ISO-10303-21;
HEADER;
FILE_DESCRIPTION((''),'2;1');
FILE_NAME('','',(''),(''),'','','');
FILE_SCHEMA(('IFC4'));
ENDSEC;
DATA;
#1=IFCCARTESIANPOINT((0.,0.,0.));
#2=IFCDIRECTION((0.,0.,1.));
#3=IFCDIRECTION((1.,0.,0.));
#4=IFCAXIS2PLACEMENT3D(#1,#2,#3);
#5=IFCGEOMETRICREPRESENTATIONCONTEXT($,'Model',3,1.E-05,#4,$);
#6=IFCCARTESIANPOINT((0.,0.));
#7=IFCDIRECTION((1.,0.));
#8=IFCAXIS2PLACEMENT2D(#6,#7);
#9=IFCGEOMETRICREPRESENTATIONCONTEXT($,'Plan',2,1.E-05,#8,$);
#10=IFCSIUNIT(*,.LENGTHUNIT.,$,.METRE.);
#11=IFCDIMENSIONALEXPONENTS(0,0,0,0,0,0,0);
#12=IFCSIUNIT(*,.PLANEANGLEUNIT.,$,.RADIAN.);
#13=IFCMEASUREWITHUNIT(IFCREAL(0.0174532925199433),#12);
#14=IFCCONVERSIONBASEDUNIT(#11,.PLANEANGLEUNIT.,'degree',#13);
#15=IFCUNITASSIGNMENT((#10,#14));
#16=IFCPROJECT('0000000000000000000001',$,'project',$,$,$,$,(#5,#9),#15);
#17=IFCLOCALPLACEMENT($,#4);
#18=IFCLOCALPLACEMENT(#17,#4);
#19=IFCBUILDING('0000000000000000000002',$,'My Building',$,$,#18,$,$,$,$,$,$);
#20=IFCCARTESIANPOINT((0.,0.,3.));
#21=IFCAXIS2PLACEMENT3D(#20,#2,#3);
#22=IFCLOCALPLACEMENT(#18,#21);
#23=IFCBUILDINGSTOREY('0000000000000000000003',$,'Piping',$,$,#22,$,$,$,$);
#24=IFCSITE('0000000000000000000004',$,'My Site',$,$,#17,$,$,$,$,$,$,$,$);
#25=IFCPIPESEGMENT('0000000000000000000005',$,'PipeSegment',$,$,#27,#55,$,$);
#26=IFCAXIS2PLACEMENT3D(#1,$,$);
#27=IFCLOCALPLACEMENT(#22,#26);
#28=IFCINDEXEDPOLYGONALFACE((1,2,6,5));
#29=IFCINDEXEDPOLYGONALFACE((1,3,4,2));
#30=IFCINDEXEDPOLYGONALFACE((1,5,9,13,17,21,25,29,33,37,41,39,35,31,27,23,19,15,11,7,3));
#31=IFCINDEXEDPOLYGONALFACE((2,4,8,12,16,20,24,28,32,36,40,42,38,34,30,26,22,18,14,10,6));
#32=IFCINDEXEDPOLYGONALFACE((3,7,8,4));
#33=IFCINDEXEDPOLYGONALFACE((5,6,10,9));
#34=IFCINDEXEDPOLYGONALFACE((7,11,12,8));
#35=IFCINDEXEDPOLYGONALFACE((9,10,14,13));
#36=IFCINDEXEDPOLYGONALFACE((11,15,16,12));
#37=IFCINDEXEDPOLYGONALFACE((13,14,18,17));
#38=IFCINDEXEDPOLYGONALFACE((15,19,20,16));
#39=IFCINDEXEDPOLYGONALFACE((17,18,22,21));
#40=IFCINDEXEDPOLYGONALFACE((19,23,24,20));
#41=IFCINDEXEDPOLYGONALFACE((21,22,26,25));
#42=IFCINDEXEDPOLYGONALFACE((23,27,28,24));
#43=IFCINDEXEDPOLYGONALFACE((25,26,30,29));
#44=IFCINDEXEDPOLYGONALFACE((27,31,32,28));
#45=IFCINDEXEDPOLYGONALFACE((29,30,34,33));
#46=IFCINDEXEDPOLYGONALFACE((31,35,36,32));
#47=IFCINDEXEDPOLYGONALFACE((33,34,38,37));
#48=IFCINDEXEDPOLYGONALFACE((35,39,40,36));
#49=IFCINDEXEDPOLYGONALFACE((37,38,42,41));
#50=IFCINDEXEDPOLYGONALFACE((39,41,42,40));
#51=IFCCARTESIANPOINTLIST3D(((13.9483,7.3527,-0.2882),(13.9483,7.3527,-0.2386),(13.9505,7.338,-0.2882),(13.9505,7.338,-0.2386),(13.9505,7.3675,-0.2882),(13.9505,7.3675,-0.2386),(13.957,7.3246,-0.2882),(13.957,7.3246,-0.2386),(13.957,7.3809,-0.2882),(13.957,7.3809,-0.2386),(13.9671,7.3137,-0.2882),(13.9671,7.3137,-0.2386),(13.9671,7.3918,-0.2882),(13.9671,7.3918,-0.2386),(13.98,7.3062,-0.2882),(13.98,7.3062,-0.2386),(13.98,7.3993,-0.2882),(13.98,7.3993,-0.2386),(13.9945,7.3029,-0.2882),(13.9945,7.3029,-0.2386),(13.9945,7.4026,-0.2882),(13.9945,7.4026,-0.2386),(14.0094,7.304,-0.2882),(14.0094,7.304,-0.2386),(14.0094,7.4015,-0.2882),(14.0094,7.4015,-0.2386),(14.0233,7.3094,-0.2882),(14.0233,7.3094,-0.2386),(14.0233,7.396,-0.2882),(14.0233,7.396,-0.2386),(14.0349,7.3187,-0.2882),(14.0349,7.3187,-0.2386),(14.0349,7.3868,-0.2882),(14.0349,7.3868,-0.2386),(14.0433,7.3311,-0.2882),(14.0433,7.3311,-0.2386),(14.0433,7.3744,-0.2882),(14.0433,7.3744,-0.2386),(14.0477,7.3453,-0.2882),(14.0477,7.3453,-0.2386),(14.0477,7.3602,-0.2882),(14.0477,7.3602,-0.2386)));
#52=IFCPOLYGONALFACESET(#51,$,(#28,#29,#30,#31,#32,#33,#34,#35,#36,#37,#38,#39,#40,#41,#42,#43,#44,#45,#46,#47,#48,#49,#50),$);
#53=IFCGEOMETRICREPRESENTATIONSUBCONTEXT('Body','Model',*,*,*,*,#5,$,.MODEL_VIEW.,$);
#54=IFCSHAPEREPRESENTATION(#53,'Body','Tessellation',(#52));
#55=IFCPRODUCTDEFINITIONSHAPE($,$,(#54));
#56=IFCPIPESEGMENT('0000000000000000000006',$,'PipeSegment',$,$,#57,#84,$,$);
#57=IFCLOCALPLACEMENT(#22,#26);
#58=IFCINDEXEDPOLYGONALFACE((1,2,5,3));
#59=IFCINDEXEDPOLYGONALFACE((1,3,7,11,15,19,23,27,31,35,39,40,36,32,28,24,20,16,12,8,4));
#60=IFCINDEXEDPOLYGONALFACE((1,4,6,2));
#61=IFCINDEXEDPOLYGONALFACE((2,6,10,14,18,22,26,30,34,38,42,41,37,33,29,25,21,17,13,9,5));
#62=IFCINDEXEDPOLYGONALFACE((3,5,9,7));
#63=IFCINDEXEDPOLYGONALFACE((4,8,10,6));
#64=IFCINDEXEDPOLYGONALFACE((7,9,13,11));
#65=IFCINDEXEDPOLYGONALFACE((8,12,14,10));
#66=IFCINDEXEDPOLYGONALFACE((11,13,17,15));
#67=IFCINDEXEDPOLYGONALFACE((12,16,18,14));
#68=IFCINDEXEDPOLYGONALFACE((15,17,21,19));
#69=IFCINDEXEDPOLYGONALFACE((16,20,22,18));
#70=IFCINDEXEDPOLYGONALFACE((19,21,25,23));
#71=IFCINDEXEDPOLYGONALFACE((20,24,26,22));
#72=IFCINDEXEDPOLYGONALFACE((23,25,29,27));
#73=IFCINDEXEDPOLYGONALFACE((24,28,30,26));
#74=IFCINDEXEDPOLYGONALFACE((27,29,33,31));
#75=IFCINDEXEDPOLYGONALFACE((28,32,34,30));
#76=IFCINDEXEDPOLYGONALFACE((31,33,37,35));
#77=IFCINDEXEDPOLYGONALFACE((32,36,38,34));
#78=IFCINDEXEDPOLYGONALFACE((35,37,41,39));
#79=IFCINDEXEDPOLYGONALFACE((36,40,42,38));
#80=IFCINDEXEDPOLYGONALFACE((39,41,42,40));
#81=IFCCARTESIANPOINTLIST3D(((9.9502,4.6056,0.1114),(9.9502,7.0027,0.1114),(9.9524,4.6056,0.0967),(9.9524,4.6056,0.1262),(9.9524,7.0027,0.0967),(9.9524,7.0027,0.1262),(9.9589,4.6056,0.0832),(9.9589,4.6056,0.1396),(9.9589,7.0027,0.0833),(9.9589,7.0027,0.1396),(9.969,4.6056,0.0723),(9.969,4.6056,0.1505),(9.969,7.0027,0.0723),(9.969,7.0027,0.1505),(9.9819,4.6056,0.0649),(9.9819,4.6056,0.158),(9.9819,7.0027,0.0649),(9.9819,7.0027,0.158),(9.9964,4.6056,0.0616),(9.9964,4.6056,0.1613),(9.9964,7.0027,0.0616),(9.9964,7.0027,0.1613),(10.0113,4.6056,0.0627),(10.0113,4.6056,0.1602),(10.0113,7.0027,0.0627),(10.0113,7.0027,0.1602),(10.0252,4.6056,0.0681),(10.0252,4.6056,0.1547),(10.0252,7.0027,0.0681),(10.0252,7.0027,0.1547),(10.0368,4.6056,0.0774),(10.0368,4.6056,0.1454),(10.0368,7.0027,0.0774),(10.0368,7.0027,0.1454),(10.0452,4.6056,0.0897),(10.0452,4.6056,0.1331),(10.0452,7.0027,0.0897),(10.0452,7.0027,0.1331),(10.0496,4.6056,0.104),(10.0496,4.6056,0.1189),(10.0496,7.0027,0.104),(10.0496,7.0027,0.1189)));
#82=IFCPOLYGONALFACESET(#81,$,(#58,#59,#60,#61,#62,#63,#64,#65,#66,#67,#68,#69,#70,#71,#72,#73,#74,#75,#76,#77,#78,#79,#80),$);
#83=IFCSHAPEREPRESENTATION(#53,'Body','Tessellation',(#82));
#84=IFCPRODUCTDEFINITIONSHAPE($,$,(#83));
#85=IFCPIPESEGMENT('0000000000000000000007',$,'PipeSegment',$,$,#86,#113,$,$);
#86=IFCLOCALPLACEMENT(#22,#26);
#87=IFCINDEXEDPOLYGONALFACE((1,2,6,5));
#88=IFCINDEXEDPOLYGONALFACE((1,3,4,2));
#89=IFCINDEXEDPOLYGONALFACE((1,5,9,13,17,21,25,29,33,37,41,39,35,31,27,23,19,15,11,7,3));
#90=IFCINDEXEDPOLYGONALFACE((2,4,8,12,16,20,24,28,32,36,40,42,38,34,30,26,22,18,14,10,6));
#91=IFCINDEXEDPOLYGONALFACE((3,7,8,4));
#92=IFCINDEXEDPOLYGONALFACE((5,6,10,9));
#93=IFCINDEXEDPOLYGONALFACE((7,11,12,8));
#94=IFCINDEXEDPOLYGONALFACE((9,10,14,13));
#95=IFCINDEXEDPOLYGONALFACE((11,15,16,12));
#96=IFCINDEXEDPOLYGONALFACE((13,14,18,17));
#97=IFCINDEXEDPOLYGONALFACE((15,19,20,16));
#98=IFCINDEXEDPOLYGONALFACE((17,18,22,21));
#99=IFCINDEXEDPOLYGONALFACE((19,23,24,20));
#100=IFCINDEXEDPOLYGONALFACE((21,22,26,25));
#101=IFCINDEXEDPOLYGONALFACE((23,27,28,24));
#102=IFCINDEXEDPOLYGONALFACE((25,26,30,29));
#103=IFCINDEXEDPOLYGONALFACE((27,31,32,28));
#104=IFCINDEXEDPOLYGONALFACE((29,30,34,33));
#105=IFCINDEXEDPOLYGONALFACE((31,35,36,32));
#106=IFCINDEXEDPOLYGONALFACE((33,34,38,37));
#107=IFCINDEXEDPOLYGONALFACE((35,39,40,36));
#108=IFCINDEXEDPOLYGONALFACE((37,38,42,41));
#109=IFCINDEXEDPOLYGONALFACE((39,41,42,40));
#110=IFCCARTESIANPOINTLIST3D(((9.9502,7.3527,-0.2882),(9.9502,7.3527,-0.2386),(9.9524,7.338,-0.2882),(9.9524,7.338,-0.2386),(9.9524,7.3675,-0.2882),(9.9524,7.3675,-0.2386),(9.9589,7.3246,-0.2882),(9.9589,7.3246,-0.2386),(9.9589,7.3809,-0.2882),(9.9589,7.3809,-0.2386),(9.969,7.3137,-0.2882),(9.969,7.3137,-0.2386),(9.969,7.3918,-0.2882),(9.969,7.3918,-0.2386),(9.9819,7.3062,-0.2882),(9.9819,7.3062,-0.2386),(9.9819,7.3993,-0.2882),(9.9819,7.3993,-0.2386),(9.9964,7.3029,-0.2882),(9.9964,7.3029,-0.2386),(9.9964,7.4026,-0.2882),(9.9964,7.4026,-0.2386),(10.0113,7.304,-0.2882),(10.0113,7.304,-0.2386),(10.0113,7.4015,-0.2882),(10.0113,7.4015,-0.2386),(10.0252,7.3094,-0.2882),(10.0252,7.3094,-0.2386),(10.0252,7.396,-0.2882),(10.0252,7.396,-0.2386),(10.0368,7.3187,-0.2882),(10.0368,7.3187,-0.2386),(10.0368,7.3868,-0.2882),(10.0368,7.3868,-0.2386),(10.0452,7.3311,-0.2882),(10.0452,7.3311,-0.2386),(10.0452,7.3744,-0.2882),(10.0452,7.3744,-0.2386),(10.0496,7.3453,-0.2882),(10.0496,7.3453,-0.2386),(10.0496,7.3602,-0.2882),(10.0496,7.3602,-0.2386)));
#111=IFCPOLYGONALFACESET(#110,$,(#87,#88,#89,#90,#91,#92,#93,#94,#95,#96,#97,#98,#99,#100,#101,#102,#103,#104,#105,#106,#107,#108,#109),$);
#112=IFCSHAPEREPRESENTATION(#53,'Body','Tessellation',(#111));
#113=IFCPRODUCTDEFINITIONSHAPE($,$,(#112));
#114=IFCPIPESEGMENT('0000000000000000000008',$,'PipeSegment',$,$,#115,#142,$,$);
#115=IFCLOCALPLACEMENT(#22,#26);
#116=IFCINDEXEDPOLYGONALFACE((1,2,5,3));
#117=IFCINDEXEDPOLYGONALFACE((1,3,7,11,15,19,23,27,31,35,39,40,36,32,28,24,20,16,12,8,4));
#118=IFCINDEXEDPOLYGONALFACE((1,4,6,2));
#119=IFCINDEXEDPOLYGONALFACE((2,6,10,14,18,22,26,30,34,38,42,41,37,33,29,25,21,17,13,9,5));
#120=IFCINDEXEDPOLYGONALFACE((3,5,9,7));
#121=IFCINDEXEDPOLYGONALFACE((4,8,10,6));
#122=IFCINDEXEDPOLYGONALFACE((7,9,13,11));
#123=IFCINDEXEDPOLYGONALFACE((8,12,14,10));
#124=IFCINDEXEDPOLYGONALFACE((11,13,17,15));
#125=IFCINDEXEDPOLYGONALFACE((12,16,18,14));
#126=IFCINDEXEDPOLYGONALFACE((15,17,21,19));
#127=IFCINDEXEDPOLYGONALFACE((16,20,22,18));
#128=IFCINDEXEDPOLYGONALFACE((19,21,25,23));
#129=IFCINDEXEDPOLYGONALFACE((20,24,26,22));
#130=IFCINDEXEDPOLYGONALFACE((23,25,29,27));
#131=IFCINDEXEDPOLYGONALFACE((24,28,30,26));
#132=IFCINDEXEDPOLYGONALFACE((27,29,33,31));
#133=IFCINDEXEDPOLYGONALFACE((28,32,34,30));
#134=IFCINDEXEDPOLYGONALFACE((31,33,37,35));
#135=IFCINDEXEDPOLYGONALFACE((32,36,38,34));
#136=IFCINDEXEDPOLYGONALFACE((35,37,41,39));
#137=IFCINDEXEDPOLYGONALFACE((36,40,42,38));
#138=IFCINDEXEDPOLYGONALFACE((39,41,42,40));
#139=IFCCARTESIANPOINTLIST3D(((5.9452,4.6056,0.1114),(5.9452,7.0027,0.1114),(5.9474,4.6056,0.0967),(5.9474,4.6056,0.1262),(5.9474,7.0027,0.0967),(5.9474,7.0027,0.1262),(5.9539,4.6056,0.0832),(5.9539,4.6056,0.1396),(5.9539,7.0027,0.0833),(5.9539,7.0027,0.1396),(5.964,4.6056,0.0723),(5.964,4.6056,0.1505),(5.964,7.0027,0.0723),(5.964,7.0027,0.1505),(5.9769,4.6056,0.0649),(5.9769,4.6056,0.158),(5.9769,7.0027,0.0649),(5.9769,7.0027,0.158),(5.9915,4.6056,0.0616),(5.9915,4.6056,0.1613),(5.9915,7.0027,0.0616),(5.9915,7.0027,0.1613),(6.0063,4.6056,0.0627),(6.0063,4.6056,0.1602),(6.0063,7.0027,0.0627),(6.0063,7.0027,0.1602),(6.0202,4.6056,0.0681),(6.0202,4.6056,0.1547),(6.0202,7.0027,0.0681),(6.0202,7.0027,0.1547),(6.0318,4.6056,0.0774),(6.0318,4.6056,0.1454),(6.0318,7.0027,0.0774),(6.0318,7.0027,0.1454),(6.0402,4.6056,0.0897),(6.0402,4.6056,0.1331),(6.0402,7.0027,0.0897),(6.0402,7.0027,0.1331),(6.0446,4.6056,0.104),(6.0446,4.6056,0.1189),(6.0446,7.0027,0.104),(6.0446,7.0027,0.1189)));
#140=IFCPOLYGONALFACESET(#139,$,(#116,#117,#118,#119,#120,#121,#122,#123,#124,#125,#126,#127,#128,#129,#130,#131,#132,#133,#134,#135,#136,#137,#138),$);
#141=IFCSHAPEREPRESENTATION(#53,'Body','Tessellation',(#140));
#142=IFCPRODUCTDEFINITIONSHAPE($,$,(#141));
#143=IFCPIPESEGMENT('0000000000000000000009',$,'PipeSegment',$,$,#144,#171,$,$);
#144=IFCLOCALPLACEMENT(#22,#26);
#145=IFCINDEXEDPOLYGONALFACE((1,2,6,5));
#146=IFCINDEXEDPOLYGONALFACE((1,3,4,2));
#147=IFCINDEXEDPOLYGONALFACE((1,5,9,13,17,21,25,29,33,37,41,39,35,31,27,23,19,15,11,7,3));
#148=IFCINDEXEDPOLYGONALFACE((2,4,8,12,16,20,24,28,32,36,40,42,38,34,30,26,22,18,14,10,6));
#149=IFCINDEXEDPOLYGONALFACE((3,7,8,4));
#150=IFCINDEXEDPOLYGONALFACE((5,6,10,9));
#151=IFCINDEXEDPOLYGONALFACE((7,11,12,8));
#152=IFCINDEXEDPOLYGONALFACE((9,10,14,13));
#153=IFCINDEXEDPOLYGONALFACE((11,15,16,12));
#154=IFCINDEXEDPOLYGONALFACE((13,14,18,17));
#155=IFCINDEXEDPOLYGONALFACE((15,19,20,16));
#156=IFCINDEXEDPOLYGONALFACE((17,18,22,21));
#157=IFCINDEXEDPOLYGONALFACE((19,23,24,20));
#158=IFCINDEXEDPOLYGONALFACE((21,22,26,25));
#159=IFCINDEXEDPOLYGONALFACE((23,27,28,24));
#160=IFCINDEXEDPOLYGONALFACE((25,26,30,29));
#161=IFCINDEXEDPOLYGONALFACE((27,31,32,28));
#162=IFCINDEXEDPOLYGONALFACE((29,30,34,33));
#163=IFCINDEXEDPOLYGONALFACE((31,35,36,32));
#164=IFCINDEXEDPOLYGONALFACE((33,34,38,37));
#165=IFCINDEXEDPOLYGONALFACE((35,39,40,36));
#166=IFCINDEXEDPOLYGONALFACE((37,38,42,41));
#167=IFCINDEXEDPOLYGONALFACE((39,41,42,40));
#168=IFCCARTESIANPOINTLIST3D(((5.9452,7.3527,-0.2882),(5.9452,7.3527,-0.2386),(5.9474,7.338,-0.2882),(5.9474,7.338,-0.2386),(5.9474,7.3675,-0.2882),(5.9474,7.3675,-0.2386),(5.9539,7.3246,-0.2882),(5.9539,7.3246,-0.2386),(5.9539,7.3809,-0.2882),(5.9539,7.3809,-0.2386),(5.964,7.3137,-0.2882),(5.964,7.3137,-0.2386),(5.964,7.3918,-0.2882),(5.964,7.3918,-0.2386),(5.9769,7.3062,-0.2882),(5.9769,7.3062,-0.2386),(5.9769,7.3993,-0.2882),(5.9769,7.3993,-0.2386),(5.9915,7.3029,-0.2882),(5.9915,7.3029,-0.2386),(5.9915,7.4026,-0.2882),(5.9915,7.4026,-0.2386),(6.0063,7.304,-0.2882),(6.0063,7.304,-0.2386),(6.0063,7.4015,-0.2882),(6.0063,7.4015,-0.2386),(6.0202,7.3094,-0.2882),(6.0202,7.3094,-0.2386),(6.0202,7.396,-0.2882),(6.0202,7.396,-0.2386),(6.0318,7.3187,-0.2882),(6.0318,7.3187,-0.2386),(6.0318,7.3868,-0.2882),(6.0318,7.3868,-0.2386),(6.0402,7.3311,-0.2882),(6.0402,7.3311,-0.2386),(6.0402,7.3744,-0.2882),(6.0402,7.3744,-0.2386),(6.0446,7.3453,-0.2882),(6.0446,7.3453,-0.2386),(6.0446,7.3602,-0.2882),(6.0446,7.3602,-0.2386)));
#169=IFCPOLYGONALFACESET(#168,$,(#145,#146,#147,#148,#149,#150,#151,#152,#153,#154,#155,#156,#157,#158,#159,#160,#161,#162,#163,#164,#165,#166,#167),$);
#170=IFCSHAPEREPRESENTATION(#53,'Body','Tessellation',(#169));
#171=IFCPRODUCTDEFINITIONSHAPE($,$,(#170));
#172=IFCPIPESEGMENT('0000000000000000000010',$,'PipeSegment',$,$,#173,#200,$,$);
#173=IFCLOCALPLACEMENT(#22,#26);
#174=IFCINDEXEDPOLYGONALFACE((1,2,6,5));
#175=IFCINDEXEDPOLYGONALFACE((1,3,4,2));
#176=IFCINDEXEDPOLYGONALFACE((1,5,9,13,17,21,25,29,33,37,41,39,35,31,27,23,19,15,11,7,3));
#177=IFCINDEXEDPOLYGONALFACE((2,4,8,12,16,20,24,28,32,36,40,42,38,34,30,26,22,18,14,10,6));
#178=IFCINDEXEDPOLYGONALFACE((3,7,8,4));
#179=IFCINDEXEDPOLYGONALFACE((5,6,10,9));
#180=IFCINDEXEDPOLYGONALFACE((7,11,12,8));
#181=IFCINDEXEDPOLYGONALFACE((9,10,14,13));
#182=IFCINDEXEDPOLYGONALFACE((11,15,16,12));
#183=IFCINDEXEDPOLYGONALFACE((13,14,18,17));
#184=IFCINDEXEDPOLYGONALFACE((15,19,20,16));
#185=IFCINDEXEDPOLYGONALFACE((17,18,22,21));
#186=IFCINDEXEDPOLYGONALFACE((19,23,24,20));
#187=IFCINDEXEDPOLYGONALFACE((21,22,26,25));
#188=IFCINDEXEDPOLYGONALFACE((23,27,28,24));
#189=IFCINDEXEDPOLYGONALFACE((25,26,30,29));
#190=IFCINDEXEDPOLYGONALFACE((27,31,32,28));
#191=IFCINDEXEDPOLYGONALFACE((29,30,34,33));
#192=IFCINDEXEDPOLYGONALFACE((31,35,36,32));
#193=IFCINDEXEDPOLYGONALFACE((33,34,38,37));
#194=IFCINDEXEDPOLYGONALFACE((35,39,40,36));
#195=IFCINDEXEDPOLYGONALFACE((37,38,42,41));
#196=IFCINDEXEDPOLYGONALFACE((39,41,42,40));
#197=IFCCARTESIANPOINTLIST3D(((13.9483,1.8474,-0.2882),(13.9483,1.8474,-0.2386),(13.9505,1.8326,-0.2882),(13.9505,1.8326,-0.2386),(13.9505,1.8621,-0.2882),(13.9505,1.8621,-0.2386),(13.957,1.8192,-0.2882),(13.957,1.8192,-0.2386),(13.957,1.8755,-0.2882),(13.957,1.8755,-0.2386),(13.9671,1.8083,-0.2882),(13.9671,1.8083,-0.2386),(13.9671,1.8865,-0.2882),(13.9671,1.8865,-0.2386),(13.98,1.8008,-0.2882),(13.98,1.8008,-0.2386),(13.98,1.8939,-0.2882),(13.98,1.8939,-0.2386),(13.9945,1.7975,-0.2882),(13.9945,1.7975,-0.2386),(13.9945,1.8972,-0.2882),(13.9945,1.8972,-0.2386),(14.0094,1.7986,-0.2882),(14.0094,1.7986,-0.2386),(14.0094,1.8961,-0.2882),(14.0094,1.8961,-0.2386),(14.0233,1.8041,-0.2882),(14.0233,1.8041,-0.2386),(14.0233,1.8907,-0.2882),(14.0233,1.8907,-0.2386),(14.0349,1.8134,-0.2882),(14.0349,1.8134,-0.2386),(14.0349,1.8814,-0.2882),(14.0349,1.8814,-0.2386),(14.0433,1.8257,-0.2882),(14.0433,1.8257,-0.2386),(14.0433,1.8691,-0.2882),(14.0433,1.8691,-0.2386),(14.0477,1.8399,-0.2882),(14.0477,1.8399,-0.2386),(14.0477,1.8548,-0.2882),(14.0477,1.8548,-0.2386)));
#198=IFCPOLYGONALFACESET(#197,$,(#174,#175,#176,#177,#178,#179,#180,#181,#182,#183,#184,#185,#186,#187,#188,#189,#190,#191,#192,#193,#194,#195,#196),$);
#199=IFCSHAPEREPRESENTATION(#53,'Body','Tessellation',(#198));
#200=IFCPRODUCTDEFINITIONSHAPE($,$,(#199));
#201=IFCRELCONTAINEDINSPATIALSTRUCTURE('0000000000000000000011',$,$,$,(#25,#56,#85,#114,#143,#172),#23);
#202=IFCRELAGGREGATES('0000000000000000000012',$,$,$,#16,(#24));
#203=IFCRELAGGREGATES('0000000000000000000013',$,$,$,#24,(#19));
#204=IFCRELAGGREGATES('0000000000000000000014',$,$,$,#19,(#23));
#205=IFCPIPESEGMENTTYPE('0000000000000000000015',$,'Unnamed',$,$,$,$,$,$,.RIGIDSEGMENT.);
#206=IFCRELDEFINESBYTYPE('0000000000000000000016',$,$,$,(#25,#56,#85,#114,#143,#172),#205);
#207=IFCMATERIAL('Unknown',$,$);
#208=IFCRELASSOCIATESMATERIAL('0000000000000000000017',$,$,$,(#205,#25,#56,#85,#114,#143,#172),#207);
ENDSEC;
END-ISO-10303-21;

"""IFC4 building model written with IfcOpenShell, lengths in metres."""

from ifc_helpers import new_model, entity, si_unit, converted_unit, frame, origin_with_axes, origin_2d_with_axis, place, context, subcontext, project, spatial, circle, extrude, material, material_profile, profile_set, profile_usage, type_object, element, save


model = new_model("IFC4")

# Units and contexts
model_context = context("Model", 3, precision=1e-05, world=origin_with_axes())
plan_context = context("Plan", 2, precision=1e-05, world=origin_2d_with_axis())
body_context = subcontext(model_context, "Body", "Model", "MODEL_VIEW")
ifc_project = project(units=[si_unit("LENGTHUNIT", "METRE"), converted_unit("PLANEANGLEUNIT", "degree", entity("IfcReal", 0.0174532925199433), si_unit("PLANEANGLEUNIT", "RADIAN"), dimensions=[0, 0, 0, 0, 0, 0, 0])], contexts=[model_context, plan_context])

# Site, building, storey
site_placement = place(None, origin_with_axes())
site = spatial("IfcSite", under=ifc_project, at=site_placement, Name="My Site")
building_placement = place(site_placement, origin_with_axes())
building = spatial("IfcBuilding", under=site, at=building_placement, Name="My Building")
storey_placement = place(building_placement, frame((0.0, 0.0, 3.0), z_axis=(0.0, 0.0, 1.0), x_axis=(1.0, 0.0, 0.0)))
storey = spatial("IfcBuildingStorey", under=building, at=storey_placement, Name="Piping")

# Pipe segments
ifc_material = material(Name="Unknown")
ifc_material_profile_1 = material_profile(ifc_material, circle(Radius=0.05))
ifc_profile_set_1 = profile_set([ifc_material_profile_1])
pipe_segment_type = type_object("IfcPipeSegmentType", Name="Unnamed", PredefinedType="RIGIDSEGMENT", material=ifc_profile_set_1)
ifc_profile_usage_1 = profile_usage(ifc_profile_set_1, cardinal=16)
pipe_segment_1_placement = place(storey_placement, frame((13.9983, 7.3527, -0.2386), z_axis=(0.0, 0.0, -1.0), x_axis=(-1.0, 0.0, 0.0)))
element("IfcPipeSegment", 1, at=pipe_segment_1_placement, inside=storey, type_object=pipe_segment_type, material=ifc_profile_usage_1, Name="PipeSegment", context=body_context, shape_type="SweptSolid", body=[
    extrude(circle(Radius=0.05), origin_with_axes(), (0.0, 0.0, 1.0), 0.0496),
])
ifc_profile_usage_2 = profile_usage(ifc_profile_set_1, cardinal=16)
pipe_segment_2_placement = place(storey_placement, frame((10.0002, 4.6056, 0.1114), z_axis=(0.0, 1.0, 0.0), x_axis=(-1.0, 0.0, 0.0)))
element("IfcPipeSegment", 2, at=pipe_segment_2_placement, inside=storey, type_object=pipe_segment_type, material=ifc_profile_usage_2, Name="PipeSegment", context=body_context, shape_type="SweptSolid", body=[
    extrude(circle(Radius=0.05), origin_with_axes(), (0.0, 0.0, 1.0), 2.3972),
])
ifc_profile_usage_3 = profile_usage(ifc_profile_set_1, cardinal=16)
pipe_segment_3_placement = place(storey_placement, frame((10.0002, 7.3527, -0.2386), z_axis=(0.0, 0.0, -1.0), x_axis=(-1.0, 0.0, 0.0)))
element("IfcPipeSegment", 3, at=pipe_segment_3_placement, inside=storey, type_object=pipe_segment_type, material=ifc_profile_usage_3, Name="PipeSegment", context=body_context, shape_type="SweptSolid", body=[
    extrude(circle(Radius=0.05), origin_with_axes(), (0.0, 0.0, 1.0), 0.0496),
])
ifc_profile_usage_4 = profile_usage(ifc_profile_set_1, cardinal=16)
pipe_segment_4_placement = place(storey_placement, frame((5.9952, 4.6056, 0.1114), z_axis=(0.0, 1.0, 0.0), x_axis=(-1.0, 0.0, 0.0)))
element("IfcPipeSegment", 4, at=pipe_segment_4_placement, inside=storey, type_object=pipe_segment_type, material=ifc_profile_usage_4, Name="PipeSegment", context=body_context, shape_type="SweptSolid", body=[
    extrude(circle(Radius=0.05), origin_with_axes(), (0.0, 0.0, 1.0), 2.3972),
])
ifc_profile_usage_5 = profile_usage(ifc_profile_set_1, cardinal=16)
pipe_segment_5_placement = place(storey_placement, frame((5.9952, 7.3527, -0.2386), z_axis=(0.0, 0.0, -1.0), x_axis=(-1.0, 0.0, 0.0)))
element("IfcPipeSegment", 5, at=pipe_segment_5_placement, inside=storey, type_object=pipe_segment_type, material=ifc_profile_usage_5, Name="PipeSegment", context=body_context, shape_type="SweptSolid", body=[
    extrude(circle(Radius=0.05), origin_with_axes(), (0.0, 0.0, 1.0), 0.0496),
])
ifc_profile_usage_6 = profile_usage(ifc_profile_set_1, cardinal=16)
pipe_segment_6_placement = place(storey_placement, frame((13.9983, 1.8474, -0.2386), z_axis=(0.0, 0.0, -1.0), x_axis=(-1.0, 0.0, 0.0)))
element("IfcPipeSegment", 6, at=pipe_segment_6_placement, inside=storey, type_object=pipe_segment_type, material=ifc_profile_usage_6, Name="PipeSegment", context=body_context, shape_type="SweptSolid", body=[
    extrude(circle(Radius=0.05), origin_with_axes(), (0.0, 0.0, 1.0), 0.0496),
])

save(model, "model.ifc")
